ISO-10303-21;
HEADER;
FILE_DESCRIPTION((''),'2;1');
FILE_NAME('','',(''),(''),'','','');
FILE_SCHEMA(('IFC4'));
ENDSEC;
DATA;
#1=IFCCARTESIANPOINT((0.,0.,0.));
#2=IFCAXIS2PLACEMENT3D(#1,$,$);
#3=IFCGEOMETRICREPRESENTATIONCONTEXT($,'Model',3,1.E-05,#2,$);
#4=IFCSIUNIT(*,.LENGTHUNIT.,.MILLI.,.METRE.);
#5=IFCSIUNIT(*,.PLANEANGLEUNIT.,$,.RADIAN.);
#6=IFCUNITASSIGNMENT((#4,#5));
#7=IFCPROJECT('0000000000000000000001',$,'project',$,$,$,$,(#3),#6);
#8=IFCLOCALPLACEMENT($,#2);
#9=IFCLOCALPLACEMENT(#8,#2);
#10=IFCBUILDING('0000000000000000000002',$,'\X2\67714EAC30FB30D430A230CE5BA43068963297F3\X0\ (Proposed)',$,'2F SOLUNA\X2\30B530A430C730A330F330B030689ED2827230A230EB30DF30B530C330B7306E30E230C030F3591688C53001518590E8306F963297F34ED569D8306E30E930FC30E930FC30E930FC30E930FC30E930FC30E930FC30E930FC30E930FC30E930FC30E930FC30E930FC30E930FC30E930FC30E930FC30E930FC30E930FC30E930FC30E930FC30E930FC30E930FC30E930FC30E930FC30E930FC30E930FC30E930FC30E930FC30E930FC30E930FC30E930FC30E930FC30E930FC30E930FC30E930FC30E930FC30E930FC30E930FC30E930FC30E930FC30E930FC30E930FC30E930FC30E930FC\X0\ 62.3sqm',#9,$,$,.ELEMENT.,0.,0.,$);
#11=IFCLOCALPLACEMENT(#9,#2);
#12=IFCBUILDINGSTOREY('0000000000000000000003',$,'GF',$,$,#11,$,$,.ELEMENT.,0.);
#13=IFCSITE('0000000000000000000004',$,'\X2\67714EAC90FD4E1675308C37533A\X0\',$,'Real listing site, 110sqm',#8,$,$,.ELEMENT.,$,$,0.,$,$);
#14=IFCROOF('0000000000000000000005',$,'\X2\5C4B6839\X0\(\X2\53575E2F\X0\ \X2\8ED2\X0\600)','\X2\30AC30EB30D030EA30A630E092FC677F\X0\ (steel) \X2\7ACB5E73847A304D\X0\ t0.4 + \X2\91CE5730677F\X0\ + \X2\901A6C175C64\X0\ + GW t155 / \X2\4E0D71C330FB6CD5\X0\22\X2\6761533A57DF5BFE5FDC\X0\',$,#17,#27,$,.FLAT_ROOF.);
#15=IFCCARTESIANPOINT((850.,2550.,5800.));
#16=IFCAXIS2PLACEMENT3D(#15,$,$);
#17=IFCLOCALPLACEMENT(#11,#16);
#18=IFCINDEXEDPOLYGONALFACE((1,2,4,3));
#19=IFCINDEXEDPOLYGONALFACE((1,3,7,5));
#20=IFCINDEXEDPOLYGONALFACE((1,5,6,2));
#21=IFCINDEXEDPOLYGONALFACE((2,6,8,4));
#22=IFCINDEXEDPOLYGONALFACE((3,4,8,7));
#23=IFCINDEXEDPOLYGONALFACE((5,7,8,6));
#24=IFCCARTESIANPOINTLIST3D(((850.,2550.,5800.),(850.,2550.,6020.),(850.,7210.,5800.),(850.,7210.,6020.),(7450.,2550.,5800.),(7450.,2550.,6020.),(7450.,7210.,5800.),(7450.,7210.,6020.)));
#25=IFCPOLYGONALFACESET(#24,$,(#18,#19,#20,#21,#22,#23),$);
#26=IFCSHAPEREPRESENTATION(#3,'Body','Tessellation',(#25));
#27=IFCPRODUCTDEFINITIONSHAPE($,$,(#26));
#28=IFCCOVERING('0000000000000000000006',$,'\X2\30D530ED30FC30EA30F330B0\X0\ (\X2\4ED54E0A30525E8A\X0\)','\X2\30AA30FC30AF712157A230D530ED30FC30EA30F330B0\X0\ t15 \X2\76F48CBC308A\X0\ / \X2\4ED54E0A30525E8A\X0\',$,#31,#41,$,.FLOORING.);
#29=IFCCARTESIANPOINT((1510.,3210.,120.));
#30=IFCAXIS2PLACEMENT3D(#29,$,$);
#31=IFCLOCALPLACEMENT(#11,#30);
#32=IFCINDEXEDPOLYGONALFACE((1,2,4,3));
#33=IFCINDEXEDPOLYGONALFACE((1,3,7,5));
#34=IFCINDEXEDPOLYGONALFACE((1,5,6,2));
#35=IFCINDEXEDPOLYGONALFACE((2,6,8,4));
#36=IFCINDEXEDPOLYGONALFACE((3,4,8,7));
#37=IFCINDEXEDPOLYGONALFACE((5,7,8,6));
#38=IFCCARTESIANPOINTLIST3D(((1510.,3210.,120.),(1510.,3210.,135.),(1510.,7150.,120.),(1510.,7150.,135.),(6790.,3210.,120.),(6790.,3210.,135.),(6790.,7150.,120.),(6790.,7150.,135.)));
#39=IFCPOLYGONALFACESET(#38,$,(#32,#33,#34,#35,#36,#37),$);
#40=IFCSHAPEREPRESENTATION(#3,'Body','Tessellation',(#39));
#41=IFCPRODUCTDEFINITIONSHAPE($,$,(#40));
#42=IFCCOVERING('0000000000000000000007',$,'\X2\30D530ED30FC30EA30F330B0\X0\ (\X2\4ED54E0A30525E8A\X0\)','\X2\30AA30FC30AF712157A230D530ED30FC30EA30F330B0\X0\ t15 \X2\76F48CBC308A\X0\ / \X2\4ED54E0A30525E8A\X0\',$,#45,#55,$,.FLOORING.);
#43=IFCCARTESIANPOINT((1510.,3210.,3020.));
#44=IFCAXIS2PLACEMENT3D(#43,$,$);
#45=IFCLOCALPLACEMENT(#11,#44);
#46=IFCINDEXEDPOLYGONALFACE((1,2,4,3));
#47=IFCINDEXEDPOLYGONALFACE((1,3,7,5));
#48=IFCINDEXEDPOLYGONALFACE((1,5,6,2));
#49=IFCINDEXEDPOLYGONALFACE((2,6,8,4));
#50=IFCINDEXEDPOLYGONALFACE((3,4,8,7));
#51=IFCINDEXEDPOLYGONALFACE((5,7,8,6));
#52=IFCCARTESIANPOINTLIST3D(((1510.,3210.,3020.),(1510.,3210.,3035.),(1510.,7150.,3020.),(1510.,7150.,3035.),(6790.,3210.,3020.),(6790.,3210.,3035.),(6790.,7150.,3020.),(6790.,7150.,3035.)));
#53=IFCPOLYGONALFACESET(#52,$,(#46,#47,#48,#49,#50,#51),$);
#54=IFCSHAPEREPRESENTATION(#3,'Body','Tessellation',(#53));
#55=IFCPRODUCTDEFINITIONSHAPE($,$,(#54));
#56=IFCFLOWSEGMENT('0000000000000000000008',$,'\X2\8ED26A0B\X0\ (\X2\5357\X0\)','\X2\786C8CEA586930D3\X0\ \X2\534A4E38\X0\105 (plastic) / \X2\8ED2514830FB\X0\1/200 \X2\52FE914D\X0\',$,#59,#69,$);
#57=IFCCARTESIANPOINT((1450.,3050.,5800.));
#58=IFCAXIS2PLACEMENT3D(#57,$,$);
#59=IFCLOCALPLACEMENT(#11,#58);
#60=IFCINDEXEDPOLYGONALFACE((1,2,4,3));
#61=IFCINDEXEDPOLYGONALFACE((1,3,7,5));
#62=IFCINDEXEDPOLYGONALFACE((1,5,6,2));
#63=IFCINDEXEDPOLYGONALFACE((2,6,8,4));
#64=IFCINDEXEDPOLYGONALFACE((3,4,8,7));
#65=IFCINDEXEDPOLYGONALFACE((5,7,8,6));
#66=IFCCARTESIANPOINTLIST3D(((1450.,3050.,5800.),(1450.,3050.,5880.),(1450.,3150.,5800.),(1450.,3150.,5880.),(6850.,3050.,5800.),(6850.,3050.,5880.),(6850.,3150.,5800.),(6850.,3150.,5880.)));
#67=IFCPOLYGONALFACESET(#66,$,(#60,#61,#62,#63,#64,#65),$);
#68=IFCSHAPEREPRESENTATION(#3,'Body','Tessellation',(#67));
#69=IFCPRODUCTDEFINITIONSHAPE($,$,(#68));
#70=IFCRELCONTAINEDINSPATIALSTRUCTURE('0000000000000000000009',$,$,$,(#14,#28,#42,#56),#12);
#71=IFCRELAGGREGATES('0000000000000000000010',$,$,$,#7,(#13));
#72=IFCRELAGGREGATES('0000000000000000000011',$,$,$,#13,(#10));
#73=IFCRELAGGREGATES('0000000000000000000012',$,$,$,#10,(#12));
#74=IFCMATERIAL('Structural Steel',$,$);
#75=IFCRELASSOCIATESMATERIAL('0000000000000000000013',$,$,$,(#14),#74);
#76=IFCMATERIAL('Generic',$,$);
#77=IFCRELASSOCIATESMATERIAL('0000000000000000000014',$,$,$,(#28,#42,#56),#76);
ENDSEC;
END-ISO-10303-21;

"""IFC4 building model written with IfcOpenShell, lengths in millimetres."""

from ifc_helpers import new_model, si_unit, frame, frame_2d, origin, place, context, project, spatial, rectangle, extrude, material, element, save


model = new_model("IFC4")

# Units and contexts
model_context = context("Model", 3, precision=1e-05, world=origin())
ifc_project = project(units=[si_unit("LENGTHUNIT", "METRE", prefix="MILLI"), si_unit("PLANEANGLEUNIT", "RADIAN")], contexts=[model_context])

# Site, building, storey
site_placement = place(None, origin())
site = spatial("IfcSite", under=ifc_project, at=site_placement, Name="東京都世田谷区", ObjectType="Real listing site, 110sqm", CompositionType="ELEMENT", RefElevation=0.0)
building_placement = place(site_placement, origin())
building = spatial("IfcBuilding", under=site, at=building_placement, Name="東京・ピアノ室と防音 (Proposed)", ObjectType="2F SOLUNAサイディングと黒色アルミサッシのモダン外装、内部は防音仕様のラーラーラーラーラーラーラーラーラーラーラーラーラーラーラーラーラーラーラーラーラーラーラーラーラーラーラーラーラーラーラーラーラーラーラーラーラーラーラーラーラーラー 62.3sqm", CompositionType="ELEMENT", ElevationOfRefHeight=0.0, ElevationOfTerrain=0.0)
storey_placement = place(building_placement, origin())
storey = spatial("IfcBuildingStorey", under=building, at=storey_placement, Name="GF", CompositionType="ELEMENT", Elevation=0.0)

# Roof
ifc_material_1 = material(Name="Structural Steel")
for number, where, name in (
    (1, (850.0, 2550.0, 5800.0), "屋根(南帯 軒600)"),
):
    element("IfcRoof", number, at=place(storey_placement, frame(where)), inside=storey, material=ifc_material_1, Name=name, Description="ガルバリウム鋼板 (steel) 立平葺き t0.4 + 野地板 + 通気層 + GW t155 / 不燃・法22条区域対応", PredefinedType="FLAT_ROOF", context=model_context, shape_type="SweptSolid", body=[
        extrude(rectangle(XDim=6600.0, YDim=4660.0, at=frame_2d((3300.0, 2330.0))), frame((850.0, 2550.0, 5800.0)), (0.0, 0.0, 1.0), 220.0),
    ])

# Coverings
ifc_material_2 = material(Name="Generic")
covering_1_placement = place(storey_placement, frame((1510.0, 3210.0, 120.0)))
element("IfcCovering", 2, at=covering_1_placement, inside=storey, material=ifc_material_2, Name="フローリング (仕上げ床)", Description="オーク無垢フローリング t15 直貼り / 仕上げ床", PredefinedType="FLOORING", context=model_context, shape_type="SweptSolid", body=[
    extrude(rectangle(XDim=5280.0, YDim=3940.0, at=frame_2d((2640.0, 1970.0))), frame((1510.0, 3210.0, 120.0)), (0.0, 0.0, 1.0), 15.0),
])
covering_2_placement = place(storey_placement, frame((1510.0, 3210.0, 3020.0)))
element("IfcCovering", 3, at=covering_2_placement, inside=storey, material=ifc_material_2, Name="フローリング (仕上げ床)", Description="オーク無垢フローリング t15 直貼り / 仕上げ床", PredefinedType="FLOORING", context=model_context, shape_type="SweptSolid", body=[
    extrude(rectangle(XDim=5280.0, YDim=3940.0, at=frame_2d((2640.0, 1970.0))), frame((1510.0, 3210.0, 3020.0)), (0.0, 0.0, 1.0), 15.0),
])

# Flow segment
flow_segment_placement = place(storey_placement, frame((1450.0, 3050.0, 5800.0)))
element("IfcFlowSegment", 4, at=flow_segment_placement, inside=storey, material=ifc_material_2, Name="軒樋 (南)", Description="硬質塩ビ 半丸105 (plastic) / 軒先・1/200 勾配", context=model_context, shape_type="SweptSolid", body=[
    extrude(rectangle(XDim=5400.0, YDim=100.0, at=frame_2d((2700.0, 50.0))), frame((1450.0, 3050.0, 5800.0)), (0.0, 0.0, 1.0), 80.0),
])

save(model, "model.ifc")
